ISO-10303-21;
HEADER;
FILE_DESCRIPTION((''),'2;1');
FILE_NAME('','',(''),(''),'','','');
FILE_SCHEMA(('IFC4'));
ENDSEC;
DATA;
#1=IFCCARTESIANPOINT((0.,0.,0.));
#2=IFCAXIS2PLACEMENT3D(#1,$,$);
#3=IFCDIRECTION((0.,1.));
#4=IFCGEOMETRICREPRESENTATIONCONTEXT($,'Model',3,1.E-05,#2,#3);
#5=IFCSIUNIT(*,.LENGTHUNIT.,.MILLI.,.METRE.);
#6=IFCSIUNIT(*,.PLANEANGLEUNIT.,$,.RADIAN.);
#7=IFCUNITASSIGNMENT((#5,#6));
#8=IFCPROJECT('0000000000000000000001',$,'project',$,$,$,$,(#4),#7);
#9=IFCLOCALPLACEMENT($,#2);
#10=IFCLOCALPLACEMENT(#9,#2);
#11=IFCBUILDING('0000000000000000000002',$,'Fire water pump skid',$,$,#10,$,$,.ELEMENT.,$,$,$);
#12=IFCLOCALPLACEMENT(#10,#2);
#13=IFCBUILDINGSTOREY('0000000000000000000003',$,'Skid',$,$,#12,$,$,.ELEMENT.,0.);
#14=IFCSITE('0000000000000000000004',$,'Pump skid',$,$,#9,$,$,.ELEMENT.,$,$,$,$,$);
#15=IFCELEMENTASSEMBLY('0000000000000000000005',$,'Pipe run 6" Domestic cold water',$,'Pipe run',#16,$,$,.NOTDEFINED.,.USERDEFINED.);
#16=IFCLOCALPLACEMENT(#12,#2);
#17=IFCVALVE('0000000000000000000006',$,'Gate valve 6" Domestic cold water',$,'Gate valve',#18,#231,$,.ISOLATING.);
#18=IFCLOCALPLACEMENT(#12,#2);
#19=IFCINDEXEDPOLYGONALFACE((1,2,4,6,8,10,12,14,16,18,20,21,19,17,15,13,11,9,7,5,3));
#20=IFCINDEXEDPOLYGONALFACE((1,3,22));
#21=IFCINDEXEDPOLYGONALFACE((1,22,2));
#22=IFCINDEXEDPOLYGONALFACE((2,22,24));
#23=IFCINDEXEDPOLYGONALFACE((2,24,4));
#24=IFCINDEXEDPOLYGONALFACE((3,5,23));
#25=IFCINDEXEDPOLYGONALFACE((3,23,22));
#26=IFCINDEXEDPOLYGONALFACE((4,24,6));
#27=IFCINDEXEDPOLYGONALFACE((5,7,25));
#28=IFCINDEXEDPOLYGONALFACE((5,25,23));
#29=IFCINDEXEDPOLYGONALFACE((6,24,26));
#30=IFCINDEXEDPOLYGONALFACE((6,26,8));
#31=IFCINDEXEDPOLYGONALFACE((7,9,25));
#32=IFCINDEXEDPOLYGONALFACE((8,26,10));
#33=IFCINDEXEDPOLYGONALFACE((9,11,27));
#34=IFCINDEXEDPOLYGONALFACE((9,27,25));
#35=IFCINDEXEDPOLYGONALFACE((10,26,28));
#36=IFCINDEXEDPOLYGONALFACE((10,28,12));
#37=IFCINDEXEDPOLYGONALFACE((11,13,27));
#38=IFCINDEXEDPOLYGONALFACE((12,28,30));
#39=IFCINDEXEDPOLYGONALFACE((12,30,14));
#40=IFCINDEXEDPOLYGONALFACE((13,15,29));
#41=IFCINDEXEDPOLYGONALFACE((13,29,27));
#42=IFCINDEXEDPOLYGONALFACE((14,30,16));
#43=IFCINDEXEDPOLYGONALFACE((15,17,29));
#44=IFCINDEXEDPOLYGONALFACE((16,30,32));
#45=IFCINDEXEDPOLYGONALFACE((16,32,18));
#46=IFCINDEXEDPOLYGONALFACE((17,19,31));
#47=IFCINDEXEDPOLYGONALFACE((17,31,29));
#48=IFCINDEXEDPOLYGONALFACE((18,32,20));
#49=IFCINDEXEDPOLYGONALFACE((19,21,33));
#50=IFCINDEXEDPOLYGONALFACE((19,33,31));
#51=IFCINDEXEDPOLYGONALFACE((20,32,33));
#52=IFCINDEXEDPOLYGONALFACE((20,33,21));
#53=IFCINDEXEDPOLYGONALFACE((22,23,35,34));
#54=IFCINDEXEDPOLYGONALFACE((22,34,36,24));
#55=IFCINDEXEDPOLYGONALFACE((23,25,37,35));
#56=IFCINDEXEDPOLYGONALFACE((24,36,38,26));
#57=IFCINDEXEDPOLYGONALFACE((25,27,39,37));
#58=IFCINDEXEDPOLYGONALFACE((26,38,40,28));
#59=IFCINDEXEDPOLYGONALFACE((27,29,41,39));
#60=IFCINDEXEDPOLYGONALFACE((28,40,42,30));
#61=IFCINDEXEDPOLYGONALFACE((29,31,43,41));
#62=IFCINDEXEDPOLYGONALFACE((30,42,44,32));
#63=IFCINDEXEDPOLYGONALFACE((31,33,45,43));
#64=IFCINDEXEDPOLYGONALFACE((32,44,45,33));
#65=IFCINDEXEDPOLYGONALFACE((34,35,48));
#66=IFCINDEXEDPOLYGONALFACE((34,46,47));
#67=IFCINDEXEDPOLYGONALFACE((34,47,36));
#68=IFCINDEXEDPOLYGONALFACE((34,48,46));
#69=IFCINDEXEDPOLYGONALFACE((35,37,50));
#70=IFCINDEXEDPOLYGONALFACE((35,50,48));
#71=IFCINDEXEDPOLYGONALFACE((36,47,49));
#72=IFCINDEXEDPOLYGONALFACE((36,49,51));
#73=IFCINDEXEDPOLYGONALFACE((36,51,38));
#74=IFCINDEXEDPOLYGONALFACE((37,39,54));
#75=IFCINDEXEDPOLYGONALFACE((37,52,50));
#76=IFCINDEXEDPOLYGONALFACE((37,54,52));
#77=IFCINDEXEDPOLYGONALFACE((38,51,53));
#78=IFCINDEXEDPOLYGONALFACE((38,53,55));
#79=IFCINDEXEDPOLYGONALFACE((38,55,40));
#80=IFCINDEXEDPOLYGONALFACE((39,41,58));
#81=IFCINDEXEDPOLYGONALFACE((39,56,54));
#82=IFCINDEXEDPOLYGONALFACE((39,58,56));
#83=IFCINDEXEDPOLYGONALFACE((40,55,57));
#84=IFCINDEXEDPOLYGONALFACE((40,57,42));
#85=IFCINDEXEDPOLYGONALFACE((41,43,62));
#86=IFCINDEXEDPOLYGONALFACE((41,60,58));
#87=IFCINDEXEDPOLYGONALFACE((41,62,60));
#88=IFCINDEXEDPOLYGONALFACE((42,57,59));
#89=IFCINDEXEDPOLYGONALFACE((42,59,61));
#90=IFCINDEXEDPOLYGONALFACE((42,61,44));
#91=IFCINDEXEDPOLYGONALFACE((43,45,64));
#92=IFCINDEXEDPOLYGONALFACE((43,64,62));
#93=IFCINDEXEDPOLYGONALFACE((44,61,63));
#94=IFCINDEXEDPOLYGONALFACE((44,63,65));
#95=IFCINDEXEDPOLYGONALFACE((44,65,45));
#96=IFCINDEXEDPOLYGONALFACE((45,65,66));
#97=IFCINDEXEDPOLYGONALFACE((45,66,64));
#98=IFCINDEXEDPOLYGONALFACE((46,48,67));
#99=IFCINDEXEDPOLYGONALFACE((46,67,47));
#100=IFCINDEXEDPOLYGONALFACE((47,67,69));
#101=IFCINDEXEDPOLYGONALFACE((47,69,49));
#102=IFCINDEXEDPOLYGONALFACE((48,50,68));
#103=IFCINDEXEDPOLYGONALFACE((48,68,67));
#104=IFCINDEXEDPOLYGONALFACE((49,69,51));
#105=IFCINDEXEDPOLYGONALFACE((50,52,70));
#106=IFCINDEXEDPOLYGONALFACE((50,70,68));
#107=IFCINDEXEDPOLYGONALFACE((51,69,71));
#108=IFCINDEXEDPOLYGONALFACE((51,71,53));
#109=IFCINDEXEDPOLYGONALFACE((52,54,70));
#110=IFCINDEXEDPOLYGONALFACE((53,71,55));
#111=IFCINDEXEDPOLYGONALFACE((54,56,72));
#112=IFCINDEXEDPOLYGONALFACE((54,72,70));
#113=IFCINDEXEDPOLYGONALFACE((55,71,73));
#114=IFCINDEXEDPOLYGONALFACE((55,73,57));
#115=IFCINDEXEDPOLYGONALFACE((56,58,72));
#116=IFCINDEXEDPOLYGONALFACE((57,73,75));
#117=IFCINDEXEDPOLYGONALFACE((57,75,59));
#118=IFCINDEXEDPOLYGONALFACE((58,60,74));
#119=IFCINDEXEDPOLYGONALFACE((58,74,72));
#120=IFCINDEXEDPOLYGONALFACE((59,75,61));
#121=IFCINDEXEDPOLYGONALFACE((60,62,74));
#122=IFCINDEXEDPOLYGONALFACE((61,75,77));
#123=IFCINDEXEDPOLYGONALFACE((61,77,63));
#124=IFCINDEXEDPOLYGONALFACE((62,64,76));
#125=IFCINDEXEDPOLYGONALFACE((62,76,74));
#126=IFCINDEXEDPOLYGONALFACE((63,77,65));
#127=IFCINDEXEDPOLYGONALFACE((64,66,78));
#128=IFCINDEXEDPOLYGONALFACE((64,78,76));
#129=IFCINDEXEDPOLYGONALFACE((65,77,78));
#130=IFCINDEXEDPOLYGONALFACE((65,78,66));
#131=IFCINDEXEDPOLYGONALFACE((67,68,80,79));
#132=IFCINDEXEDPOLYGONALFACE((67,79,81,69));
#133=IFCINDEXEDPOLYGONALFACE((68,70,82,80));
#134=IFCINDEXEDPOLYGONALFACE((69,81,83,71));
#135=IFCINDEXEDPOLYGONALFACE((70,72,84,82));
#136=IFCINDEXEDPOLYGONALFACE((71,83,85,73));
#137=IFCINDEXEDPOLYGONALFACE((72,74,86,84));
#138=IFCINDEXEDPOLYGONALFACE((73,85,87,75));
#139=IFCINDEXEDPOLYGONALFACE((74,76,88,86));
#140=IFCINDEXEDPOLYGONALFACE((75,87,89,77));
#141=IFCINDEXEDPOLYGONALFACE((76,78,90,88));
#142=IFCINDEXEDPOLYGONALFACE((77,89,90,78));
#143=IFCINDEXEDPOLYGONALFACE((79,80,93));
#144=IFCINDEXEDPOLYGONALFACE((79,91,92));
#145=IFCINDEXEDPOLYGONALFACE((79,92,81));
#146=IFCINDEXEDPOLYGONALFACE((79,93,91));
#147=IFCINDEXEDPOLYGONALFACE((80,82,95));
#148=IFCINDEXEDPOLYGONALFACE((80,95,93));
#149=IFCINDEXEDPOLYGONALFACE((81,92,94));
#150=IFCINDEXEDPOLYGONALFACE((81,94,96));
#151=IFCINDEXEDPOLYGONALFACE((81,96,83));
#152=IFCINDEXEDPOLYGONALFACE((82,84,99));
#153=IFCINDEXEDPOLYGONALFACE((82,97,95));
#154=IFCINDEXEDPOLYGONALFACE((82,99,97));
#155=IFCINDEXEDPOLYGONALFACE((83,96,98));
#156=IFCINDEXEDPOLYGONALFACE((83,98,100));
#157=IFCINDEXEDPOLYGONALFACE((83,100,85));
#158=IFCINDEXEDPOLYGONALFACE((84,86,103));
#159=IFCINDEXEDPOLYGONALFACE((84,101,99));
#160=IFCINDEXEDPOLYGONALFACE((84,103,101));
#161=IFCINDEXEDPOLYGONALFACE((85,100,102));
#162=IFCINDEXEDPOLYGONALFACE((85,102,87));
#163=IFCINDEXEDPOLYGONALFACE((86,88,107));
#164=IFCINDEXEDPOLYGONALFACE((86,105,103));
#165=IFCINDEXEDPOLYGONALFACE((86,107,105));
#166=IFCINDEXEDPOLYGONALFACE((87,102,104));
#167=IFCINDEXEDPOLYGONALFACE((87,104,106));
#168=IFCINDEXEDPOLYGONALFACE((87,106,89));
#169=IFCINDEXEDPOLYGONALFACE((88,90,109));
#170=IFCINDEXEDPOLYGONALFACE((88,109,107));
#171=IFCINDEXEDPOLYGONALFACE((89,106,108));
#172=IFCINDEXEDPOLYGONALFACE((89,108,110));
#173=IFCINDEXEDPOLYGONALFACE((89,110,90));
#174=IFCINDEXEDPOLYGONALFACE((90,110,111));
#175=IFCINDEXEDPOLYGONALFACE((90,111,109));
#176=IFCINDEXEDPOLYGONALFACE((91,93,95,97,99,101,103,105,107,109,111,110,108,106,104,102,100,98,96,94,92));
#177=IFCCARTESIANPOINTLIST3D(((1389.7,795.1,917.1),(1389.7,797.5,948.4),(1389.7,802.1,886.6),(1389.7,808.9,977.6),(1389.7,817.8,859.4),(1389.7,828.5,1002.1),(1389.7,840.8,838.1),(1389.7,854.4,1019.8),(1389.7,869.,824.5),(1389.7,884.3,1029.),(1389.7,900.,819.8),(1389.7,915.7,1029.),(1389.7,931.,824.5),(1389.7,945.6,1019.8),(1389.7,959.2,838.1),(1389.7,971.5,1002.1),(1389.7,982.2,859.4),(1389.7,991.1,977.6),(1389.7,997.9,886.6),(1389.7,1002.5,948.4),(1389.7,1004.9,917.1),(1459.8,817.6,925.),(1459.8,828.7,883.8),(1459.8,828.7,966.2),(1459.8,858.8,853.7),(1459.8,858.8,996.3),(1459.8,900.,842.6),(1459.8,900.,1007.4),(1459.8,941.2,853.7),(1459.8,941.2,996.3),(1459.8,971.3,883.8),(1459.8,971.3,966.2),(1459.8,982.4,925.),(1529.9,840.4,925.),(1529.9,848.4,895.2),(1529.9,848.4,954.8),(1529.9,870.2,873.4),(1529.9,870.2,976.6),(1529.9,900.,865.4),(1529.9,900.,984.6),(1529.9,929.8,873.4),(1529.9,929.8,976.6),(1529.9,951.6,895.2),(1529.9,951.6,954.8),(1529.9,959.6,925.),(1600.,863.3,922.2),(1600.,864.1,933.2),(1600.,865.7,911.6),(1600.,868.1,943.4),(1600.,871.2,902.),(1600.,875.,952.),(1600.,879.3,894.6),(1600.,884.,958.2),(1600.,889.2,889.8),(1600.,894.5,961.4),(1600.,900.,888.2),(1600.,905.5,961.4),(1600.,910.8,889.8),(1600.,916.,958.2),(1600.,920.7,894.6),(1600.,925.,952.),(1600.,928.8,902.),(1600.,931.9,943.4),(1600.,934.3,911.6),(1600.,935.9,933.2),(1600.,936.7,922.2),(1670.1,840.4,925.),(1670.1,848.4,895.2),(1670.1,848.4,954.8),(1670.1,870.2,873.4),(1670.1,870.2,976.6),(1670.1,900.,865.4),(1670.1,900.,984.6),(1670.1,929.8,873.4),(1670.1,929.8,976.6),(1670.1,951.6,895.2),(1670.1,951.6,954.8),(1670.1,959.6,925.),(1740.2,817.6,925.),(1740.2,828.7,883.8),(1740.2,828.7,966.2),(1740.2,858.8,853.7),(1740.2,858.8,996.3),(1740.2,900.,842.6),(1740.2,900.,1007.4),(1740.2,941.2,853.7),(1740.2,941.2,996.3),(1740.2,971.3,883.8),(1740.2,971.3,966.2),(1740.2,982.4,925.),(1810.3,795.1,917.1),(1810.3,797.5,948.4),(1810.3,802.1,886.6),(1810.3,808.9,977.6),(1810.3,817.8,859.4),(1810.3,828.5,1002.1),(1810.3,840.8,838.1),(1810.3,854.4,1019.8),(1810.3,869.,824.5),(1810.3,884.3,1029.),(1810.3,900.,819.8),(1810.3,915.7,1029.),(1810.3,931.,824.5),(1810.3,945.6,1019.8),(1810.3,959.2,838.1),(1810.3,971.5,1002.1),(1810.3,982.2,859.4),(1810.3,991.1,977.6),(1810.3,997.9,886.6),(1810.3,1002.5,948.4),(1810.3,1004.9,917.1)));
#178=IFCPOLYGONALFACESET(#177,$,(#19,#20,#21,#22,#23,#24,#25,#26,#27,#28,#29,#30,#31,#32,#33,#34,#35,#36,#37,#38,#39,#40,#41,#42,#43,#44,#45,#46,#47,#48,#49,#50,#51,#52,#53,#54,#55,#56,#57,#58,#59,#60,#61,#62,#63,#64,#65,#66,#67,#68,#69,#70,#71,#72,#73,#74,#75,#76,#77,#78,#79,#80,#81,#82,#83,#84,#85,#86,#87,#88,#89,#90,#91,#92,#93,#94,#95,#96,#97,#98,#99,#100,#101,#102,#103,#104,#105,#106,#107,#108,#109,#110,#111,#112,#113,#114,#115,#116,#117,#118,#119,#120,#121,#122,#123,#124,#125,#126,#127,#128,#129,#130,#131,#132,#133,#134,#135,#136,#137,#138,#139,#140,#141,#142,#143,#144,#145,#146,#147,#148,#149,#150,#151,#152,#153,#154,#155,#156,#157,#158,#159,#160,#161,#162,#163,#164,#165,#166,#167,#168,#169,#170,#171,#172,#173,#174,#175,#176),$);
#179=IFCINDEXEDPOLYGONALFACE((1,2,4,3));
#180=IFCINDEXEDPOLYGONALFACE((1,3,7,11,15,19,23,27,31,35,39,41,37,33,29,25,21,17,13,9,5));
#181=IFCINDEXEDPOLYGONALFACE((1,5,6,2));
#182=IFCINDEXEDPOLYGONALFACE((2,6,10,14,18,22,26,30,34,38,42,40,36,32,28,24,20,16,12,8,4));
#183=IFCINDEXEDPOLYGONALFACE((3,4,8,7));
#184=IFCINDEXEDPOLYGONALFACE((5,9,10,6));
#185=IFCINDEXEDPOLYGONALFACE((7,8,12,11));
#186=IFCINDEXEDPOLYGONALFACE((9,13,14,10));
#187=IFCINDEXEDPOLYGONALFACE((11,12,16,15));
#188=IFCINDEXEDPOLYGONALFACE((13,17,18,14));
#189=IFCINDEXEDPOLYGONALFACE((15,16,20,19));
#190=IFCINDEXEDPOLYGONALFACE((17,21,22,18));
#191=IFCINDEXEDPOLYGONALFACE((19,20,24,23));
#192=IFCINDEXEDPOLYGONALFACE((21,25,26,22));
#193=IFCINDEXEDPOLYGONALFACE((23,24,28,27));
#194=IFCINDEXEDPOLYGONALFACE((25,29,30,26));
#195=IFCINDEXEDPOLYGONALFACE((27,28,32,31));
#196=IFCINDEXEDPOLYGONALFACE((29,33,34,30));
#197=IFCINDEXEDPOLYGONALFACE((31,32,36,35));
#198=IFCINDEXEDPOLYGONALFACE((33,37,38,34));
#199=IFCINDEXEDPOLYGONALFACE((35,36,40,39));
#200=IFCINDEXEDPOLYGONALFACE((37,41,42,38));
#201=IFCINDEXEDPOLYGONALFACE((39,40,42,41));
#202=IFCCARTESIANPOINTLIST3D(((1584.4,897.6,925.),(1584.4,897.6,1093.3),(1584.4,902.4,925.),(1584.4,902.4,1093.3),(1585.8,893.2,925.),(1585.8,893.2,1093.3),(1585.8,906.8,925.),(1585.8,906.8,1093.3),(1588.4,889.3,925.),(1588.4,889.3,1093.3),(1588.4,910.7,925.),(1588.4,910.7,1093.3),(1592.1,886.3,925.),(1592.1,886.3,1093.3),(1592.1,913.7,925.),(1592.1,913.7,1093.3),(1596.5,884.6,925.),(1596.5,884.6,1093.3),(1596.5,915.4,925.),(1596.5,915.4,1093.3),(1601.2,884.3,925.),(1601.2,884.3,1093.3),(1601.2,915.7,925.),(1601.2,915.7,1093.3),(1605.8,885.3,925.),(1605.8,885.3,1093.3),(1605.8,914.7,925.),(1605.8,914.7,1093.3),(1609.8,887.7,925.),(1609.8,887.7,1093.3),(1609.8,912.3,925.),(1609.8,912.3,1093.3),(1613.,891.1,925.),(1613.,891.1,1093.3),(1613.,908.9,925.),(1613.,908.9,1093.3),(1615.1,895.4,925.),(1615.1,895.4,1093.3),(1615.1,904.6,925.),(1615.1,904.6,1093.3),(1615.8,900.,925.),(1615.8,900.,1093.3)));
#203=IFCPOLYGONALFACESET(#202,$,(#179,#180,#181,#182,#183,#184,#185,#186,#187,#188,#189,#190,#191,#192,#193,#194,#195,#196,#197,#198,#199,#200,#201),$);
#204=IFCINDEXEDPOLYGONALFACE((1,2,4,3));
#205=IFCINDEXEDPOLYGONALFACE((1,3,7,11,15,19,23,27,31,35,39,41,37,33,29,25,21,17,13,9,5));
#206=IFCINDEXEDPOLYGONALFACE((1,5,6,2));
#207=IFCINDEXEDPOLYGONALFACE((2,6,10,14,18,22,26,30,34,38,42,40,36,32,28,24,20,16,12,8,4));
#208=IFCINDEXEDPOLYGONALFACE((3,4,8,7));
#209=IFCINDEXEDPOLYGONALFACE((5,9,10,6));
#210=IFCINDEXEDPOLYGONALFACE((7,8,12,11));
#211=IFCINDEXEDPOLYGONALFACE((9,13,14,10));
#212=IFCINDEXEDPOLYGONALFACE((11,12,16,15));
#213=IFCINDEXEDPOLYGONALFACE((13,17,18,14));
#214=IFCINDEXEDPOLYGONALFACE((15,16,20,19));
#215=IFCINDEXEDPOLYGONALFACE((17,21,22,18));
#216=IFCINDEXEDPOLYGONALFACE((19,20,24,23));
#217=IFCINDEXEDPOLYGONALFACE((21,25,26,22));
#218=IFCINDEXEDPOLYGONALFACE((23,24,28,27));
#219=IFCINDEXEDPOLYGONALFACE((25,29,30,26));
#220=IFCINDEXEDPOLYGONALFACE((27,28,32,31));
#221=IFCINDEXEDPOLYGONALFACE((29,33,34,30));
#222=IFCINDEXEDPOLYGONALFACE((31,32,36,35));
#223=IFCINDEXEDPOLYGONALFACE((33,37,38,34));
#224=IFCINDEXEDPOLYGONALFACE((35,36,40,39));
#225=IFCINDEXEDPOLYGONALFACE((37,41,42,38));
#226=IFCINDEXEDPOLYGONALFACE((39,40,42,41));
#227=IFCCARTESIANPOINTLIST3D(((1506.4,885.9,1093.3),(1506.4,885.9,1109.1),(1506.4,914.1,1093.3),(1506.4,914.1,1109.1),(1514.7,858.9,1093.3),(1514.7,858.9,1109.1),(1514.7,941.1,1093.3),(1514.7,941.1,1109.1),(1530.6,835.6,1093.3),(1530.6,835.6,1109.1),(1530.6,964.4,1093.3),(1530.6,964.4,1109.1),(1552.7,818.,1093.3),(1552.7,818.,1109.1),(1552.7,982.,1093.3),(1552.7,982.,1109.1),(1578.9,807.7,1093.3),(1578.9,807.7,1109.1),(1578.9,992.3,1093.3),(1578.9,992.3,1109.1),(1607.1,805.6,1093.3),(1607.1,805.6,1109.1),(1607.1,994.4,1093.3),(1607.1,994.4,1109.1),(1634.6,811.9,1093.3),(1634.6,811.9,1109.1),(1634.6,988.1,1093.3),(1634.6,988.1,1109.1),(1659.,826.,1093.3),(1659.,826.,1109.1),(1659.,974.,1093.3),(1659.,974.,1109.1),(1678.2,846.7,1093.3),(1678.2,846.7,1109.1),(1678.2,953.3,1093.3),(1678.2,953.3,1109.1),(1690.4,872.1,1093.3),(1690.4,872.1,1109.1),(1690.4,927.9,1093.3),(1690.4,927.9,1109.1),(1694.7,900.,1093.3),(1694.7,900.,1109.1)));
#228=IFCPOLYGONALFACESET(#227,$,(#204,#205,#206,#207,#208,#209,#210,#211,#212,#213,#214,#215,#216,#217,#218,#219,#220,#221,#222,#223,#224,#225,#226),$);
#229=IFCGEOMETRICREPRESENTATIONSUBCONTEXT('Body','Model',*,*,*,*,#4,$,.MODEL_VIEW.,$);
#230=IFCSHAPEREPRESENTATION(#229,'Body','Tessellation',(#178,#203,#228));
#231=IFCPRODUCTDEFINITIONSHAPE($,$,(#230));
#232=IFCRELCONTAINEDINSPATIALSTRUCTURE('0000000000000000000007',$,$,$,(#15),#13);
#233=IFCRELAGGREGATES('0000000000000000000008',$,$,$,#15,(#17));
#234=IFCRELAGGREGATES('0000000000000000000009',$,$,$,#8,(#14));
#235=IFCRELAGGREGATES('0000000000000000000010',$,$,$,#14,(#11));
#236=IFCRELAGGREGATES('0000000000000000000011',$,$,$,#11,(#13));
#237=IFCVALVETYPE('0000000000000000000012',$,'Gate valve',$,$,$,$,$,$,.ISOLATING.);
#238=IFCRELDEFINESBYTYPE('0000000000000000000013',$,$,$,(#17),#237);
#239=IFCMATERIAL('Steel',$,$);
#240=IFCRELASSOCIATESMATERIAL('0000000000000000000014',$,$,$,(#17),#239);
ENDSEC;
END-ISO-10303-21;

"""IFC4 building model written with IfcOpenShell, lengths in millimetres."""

from ifc_helpers import new_model, entity, si_unit, direction, frame, origin, origin_with_axes, origin_2d, place, context, subcontext, project, spatial, circle, extrude, material, type_object, element, aggregate, save


model = new_model("IFC4")

# Units and contexts
model_context = context("Model", 3, precision=1e-05, world=origin(), true_north=direction((0.0, 1.0)))
body_context = subcontext(model_context, "Body", "Model", "MODEL_VIEW")
ifc_project = project(units=[si_unit("LENGTHUNIT", "METRE", prefix="MILLI"), si_unit("PLANEANGLEUNIT", "RADIAN")], contexts=[model_context])

# Site, building, storey
site_placement = place(None, origin())
site = spatial("IfcSite", under=ifc_project, at=site_placement, Name="Pump skid", CompositionType="ELEMENT")
building_placement = place(site_placement, origin())
building = spatial("IfcBuilding", under=site, at=building_placement, Name="Fire water pump skid", CompositionType="ELEMENT")
storey_placement = place(building_placement, origin())
storey = spatial("IfcBuildingStorey", under=building, at=storey_placement, Name="Skid", CompositionType="ELEMENT", Elevation=0.0)

# Element assembly
ifc_material = material(Name="Steel")
assembly_1_placement = place(storey_placement, origin_with_axes())
assembly_1 = element("IfcElementAssembly", 1, at=assembly_1_placement, inside=storey, Name="Pipe run 6\" Domestic cold water", ObjectType="Pipe run", AssemblyPlace="NOTDEFINED", PredefinedType="USERDEFINED")

# Valve
valve_type_1 = type_object("IfcValveType", Name="Gate valve", PredefinedType="ISOLATING")
valve_1_placement = place(storey_placement, origin_with_axes())
cartesian_point_1 = entity("IfcCartesianPoint", [0.0, 0.0])
valve_1 = element("IfcValve", 2, at=valve_1_placement, type_object=valve_type_1, material=ifc_material, Name="Gate valve 6\" Domestic cold water", ObjectType="Gate valve", PredefinedType="ISOLATING", context=body_context, shape_type="SweptSolid", body=[
    entity("IfcRevolvedAreaSolid", entity("IfcArbitraryClosedProfileDef", "AREA", None, entity("IfcPolyline", [cartesian_point_1, entity("IfcCartesianPoint", [0.0, 105.2]), entity("IfcCartesianPoint", [210.3, 36.8]), entity("IfcCartesianPoint", [420.7, 105.2]), entity("IfcCartesianPoint", [420.7, 0.0]), cartesian_point_1])), entity("IfcAxis2Placement3D", entity("IfcCartesianPoint", [1389.7, 900.0, 925.0]), entity("IfcDirection", [0.0, 1.0, 0.0]), entity("IfcDirection", [1.0, 0.0, 0.0])), entity("IfcAxis1Placement", entity("IfcCartesianPoint", [0.0, 0.0, 0.0]), entity("IfcDirection", [1.0, 0.0, 0.0])), 6.283185),
    extrude(circle(Radius=15.8, at=origin_2d()), frame((1600.0, 900.0, 925.0), z_axis=(0.0, 0.0, 1.0), x_axis=(1.0, 0.0, 0.0)), (0.0, 0.0, 1.0), 168.3),
    extrude(circle(Radius=94.7, at=origin_2d()), frame((1600.0, 900.0, 1093.3), z_axis=(0.0, 0.0, 1.0), x_axis=(1.0, 0.0, 0.0)), (0.0, 0.0, 1.0), 15.8),
])
aggregate(assembly_1, [valve_1])

save(model, "model.ifc")
